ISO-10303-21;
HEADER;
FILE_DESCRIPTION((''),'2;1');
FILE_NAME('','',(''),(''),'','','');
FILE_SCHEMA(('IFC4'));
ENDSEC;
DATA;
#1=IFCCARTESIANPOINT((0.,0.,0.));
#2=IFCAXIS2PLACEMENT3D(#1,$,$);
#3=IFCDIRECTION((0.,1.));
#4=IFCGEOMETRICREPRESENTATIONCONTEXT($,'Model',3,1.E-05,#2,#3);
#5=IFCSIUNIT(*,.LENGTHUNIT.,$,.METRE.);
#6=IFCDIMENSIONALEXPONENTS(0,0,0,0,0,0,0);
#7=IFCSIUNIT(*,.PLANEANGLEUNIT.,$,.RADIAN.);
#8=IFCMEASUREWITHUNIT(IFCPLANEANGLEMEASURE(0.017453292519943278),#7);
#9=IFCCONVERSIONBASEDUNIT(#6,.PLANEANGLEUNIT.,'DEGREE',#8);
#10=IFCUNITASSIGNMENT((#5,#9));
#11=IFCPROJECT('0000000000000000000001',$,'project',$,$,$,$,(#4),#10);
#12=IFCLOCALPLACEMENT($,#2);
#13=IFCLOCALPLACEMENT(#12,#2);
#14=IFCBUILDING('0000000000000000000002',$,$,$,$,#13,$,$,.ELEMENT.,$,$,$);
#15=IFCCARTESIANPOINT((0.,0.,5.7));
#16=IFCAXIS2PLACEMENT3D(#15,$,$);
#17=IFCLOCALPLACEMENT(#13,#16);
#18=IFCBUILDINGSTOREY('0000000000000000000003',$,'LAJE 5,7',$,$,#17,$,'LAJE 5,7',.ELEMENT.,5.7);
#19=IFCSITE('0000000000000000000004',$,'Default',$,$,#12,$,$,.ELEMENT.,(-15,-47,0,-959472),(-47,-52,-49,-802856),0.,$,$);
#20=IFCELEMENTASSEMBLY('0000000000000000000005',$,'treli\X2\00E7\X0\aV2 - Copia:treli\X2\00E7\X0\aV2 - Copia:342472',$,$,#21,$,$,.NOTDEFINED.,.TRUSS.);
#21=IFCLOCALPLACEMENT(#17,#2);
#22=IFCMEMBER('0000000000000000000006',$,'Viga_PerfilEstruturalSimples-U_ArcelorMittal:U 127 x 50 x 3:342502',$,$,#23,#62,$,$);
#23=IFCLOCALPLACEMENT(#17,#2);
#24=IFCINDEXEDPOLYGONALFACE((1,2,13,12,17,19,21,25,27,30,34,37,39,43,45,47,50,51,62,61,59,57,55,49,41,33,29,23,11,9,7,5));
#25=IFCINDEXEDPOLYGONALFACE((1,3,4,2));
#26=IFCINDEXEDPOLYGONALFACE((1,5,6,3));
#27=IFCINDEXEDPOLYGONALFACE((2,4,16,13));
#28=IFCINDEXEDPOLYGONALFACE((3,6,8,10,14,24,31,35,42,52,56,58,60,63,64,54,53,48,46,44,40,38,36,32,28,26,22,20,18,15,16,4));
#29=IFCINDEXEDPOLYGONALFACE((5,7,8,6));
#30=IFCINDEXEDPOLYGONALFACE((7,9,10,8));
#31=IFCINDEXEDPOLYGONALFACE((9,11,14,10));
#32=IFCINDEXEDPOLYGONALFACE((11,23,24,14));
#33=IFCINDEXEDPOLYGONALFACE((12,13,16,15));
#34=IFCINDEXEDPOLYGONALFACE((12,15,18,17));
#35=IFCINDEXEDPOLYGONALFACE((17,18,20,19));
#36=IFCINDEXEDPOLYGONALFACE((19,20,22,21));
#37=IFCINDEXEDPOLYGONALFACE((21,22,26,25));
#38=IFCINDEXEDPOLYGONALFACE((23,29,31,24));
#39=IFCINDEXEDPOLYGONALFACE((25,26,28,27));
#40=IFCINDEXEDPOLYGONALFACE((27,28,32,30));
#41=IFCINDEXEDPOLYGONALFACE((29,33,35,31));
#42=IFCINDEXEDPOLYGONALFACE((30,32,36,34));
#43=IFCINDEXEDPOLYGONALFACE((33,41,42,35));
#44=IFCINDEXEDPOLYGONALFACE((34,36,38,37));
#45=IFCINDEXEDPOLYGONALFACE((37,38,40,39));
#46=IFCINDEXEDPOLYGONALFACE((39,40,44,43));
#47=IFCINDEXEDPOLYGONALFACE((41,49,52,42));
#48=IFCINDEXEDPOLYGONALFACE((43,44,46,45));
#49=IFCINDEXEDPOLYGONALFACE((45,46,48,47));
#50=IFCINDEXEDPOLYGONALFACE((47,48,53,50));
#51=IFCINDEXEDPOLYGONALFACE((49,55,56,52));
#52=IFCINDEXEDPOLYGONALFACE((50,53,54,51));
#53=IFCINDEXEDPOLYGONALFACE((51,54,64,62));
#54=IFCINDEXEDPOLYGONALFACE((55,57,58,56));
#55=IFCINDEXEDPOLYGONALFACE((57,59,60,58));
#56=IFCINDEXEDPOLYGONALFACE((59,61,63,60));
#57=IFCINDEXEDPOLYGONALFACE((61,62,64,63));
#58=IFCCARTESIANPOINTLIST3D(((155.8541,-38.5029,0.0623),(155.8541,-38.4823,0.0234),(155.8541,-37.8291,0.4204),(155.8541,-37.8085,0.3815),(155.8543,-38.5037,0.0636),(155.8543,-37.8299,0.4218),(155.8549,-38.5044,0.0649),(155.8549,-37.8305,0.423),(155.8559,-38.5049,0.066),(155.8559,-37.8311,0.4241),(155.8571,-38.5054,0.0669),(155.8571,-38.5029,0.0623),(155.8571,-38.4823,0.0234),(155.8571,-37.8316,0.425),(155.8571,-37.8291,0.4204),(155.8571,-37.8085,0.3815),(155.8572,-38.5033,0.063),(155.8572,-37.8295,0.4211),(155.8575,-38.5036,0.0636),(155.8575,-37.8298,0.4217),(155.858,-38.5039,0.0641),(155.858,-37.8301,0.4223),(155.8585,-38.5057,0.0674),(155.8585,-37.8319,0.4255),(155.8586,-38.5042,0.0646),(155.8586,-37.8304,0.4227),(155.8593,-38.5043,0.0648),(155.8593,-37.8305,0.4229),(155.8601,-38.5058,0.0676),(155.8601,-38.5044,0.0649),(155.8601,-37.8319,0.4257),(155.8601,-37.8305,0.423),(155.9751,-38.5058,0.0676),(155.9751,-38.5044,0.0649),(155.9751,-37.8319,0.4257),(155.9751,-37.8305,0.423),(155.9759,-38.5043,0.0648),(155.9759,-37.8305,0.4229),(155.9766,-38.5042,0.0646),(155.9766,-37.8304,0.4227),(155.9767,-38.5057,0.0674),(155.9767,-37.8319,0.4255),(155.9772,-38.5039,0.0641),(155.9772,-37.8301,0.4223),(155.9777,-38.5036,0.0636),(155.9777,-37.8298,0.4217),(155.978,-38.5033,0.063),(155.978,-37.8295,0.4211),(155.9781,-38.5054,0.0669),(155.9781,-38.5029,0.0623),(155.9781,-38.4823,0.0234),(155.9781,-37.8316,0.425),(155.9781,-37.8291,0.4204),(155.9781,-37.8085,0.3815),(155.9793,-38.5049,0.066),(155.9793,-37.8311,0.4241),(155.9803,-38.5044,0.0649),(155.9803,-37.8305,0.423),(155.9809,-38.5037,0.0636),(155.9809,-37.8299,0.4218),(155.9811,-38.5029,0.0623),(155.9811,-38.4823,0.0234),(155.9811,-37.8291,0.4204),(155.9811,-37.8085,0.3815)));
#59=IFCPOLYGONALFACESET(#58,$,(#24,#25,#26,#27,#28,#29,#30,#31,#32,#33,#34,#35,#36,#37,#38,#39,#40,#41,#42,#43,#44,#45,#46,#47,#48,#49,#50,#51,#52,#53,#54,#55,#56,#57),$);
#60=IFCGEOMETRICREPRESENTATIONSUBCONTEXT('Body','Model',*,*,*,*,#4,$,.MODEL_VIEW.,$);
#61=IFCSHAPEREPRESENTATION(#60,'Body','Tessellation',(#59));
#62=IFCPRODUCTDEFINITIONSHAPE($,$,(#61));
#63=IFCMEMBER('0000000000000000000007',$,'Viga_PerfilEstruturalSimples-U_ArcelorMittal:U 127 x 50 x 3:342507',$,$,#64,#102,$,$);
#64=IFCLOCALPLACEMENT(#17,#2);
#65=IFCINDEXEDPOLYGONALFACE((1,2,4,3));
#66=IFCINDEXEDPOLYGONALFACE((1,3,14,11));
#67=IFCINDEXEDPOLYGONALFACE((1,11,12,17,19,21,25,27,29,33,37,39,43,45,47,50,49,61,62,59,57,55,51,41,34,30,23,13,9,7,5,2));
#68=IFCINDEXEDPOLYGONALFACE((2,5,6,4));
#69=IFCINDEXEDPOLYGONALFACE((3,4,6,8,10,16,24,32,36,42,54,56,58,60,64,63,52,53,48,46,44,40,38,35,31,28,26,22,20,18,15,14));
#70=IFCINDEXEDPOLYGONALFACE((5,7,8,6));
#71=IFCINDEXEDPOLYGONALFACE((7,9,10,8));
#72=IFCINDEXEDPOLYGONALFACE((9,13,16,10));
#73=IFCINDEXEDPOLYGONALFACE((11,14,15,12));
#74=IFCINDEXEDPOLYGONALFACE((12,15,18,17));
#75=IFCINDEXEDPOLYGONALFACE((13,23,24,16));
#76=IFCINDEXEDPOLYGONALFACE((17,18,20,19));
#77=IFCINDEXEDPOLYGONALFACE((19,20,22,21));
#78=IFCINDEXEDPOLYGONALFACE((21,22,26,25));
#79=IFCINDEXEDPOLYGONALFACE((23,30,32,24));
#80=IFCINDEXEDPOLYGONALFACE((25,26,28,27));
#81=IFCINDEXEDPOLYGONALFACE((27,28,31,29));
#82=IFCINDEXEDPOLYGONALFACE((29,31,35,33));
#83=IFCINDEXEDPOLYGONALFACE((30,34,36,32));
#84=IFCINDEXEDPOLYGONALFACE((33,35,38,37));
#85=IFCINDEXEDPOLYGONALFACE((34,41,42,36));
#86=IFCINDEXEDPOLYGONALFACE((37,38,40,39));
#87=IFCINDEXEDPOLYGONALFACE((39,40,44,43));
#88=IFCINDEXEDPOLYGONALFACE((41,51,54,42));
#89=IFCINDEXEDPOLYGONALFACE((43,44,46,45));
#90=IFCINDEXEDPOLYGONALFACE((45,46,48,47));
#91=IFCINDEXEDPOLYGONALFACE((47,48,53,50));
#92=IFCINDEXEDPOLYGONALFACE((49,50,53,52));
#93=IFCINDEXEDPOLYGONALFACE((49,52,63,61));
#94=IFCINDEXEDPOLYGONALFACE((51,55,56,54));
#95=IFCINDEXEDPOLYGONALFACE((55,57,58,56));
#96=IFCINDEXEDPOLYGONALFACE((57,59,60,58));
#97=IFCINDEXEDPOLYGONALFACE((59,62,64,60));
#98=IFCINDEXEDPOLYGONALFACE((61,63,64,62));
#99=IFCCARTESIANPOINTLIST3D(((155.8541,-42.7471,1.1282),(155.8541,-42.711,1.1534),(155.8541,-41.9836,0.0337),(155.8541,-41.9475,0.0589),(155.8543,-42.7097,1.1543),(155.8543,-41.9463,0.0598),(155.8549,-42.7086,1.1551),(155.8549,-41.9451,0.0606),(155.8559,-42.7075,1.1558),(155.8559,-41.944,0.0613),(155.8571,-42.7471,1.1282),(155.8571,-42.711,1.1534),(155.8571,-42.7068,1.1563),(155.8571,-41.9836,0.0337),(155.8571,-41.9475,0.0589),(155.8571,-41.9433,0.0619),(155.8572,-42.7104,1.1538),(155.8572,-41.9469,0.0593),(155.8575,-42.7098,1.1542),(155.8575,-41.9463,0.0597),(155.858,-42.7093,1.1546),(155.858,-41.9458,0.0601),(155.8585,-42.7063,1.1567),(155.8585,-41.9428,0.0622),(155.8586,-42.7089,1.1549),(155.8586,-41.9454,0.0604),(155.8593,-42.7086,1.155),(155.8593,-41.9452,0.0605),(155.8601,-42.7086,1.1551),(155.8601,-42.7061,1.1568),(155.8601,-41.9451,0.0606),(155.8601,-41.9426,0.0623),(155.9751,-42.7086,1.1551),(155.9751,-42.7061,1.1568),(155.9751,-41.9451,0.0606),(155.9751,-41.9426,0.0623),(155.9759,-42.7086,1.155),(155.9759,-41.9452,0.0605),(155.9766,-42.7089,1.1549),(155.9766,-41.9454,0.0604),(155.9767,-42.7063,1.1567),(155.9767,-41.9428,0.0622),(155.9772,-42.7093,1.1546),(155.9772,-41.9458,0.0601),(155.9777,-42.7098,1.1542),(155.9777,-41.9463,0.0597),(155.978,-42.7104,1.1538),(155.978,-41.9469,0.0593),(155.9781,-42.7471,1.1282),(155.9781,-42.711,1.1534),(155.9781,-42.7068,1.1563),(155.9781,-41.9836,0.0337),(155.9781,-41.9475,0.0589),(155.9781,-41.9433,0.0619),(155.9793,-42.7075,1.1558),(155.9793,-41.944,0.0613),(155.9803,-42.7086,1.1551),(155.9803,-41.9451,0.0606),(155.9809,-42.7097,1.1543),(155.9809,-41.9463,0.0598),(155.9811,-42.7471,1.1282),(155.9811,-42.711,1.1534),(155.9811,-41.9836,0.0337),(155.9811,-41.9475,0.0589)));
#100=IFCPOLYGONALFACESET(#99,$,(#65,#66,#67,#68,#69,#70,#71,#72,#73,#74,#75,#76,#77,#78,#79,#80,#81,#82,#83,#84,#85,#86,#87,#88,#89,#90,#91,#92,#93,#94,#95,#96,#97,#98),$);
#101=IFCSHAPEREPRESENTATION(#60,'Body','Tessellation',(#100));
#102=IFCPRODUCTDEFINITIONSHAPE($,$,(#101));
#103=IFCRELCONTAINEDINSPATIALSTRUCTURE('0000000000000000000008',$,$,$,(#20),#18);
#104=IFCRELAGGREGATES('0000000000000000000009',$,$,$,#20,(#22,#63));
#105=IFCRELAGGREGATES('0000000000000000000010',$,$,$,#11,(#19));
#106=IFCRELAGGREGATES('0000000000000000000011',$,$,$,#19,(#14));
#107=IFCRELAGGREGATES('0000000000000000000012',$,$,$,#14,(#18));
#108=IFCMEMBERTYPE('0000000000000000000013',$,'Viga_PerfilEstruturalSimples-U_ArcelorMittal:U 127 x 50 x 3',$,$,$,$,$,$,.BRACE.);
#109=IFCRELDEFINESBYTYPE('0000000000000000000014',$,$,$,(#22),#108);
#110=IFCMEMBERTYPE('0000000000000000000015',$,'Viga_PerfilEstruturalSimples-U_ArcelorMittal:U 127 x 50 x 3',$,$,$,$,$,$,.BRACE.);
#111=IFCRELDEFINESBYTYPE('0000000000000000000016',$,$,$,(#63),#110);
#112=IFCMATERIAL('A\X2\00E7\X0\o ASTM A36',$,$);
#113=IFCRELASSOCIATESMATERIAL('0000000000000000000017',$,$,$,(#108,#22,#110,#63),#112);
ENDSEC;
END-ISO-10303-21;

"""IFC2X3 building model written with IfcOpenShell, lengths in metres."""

from ifc_helpers import new_model, entity, si_unit, converted_unit, direction, frame, frame_2d, origin, place, context, subcontext, project, spatial, polyline, circle_curve, parameter, trimmed, segment, composite_curve, outline, extrude, source, transform, mapped, material, type_object, type_shapes, element, aggregate, save


model = new_model("IFC2X3")

# Units and contexts
model_context = context("Model", 3, precision=1e-05, world=origin(), true_north=direction((0.0, 1.0)))
body_context = subcontext(model_context, "Body", "Model", "MODEL_VIEW")
ifc_project = project(units=[si_unit("LENGTHUNIT", "METRE"), converted_unit("PLANEANGLEUNIT", "DEGREE", entity("IfcPlaneAngleMeasure", 0.017453292519943278), si_unit("PLANEANGLEUNIT", "RADIAN"), dimensions=[0, 0, 0, 0, 0, 0, 0])], contexts=[model_context])

# Site, building, storey
site_placement = place(None, origin())
site = spatial("IfcSite", under=ifc_project, at=site_placement, Name="Default", CompositionType="ELEMENT", RefLatitude=(-15, -47, 0, -959472), RefLongitude=(-47, -52, -49, -802856), RefElevation=0.0)
building_placement = place(site_placement, origin())
building = spatial("IfcBuilding", under=site, at=building_placement, CompositionType="ELEMENT")
storey_placement = place(building_placement, frame((0.0, 0.0, 5.7)))
storey = spatial("IfcBuildingStorey", under=building, at=storey_placement, Name="LAJE 5,7", LongName="LAJE 5,7", CompositionType="ELEMENT", Elevation=5.7)

# Element assembly, members
ifc_material = material(Name="Aço ASTM A36")
assembly_1_placement = place(storey_placement, origin())
assembly_1 = element("IfcElementAssembly", 1, at=assembly_1_placement, inside=storey, Name="treliçaV2 - Copia:treliçaV2 - Copia:342472", AssemblyPlace="NOTDEFINED", PredefinedType="TRUSS")
member_type_1 = type_object("IfcMemberType", Name="Viga_PerfilEstruturalSimples-U_ArcelorMittal:U 127 x 50 x 3", PredefinedType="BRACE", material=ifc_material)
shared_shape_1 = source(origin(), body_context, "Body", "SweptSolid", [
    extrude(outline(composite_curve([segment(polyline([(-0.0575, -0.0192), (0.0575, -0.0192)]), True, "CONTINUOUS"), segment(trimmed(circle_curve(frame_2d((0.0575, -0.0132), x_axis=(0.0, 1.0)), 0.006), [parameter(180.0)], [parameter(270.0)], True, "PARAMETER"), True, "CONTINUOUS"), segment(polyline([(0.0635, -0.0132), (0.0635, 0.0308)]), True, "CONTINUOUS"), segment(polyline([(0.0635, 0.0308), (0.0605, 0.0308)]), True, "CONTINUOUS"), segment(polyline([(0.0605, 0.0308), (0.0605, -0.0132)]), True, "CONTINUOUS"), segment(trimmed(circle_curve(frame_2d((0.0575, -0.0132), x_axis=(0.0, 1.0)), 0.003), [parameter(180.0)], [parameter(270.0)], True, "PARAMETER"), False, "CONTINUOUS"), segment(polyline([(0.0575, -0.0162), (-0.0575, -0.0162)]), True, "CONTINUOUS"), segment(trimmed(circle_curve(frame_2d((-0.0575, -0.0132), x_axis=(0.0, 1.0)), 0.003), [parameter(90.0)], [parameter(180.0)], True, "PARAMETER"), False, "CONTINUOUS"), segment(polyline([(-0.0605, -0.0132), (-0.0605, 0.0308)]), True, "CONTINUOUS"), segment(polyline([(-0.0605, 0.0308), (-0.0635, 0.0308)]), True, "CONTINUOUS"), segment(polyline([(-0.0635, 0.0308), (-0.0635, -0.0132)]), True, "CONTINUOUS"), segment(trimmed(circle_curve(frame_2d((-0.0575, -0.0132), x_axis=(0.0, 1.0)), 0.006), [parameter(90.0)], [parameter(180.0)], True, "PARAMETER"), True, "CONTINUOUS")], self_intersect=False)), frame((-0.3773, -0.0058, 0.0), z_axis=(1.0, 0.0, 0.0), x_axis=(0.0, 0.0, -1.0)), (0.0, 0.0, 1.0), 0.7631),
])
type_shapes(member_type_1, [shared_shape_1])
member_1_placement = place(assembly_1_placement, frame((155.9176, -38.1609, 0.2226), z_axis=(-1.0, 0.0, 0.0), x_axis=(0.0, 0.883036, 0.469305)))
member_1 = element("IfcMember", 2, at=member_1_placement, type_object=member_type_1, material=ifc_material, Name="Viga_PerfilEstruturalSimples-U_ArcelorMittal:U 127 x 50 x 3:342502", context=body_context, shape_type="MappedRepresentation", body=[
    mapped(shared_shape_1, transform((0.0, 0.0, 0.0), scale=1.0)),
])
member_type_2 = type_object("IfcMemberType", Name="Viga_PerfilEstruturalSimples-U_ArcelorMittal:U 127 x 50 x 3", PredefinedType="BRACE", material=ifc_material)
shared_shape_2 = source(origin(), body_context, "Body", "SweptSolid", [
    extrude(outline(composite_curve([segment(polyline([(-0.0575, -0.0192), (0.0575, -0.0192)]), True, "CONTINUOUS"), segment(trimmed(circle_curve(frame_2d((0.0575, -0.0132), x_axis=(0.0, 1.0)), 0.006), [parameter(180.0)], [parameter(270.0)], True, "PARAMETER"), True, "CONTINUOUS"), segment(polyline([(0.0635, -0.0132), (0.0635, 0.0308)]), True, "CONTINUOUS"), segment(polyline([(0.0635, 0.0308), (0.0605, 0.0308)]), True, "CONTINUOUS"), segment(polyline([(0.0605, 0.0308), (0.0605, -0.0132)]), True, "CONTINUOUS"), segment(trimmed(circle_curve(frame_2d((0.0575, -0.0132), x_axis=(0.0, 1.0)), 0.003), [parameter(180.0)], [parameter(270.0)], True, "PARAMETER"), False, "CONTINUOUS"), segment(polyline([(0.0575, -0.0162), (-0.0575, -0.0162)]), True, "CONTINUOUS"), segment(trimmed(circle_curve(frame_2d((-0.0575, -0.0132), x_axis=(0.0, 1.0)), 0.003), [parameter(90.0)], [parameter(180.0)], True, "PARAMETER"), False, "CONTINUOUS"), segment(polyline([(-0.0605, -0.0132), (-0.0605, 0.0308)]), True, "CONTINUOUS"), segment(polyline([(-0.0605, 0.0308), (-0.0635, 0.0308)]), True, "CONTINUOUS"), segment(polyline([(-0.0635, 0.0308), (-0.0635, -0.0132)]), True, "CONTINUOUS"), segment(trimmed(circle_curve(frame_2d((-0.0575, -0.0132), x_axis=(0.0, 1.0)), 0.006), [parameter(90.0)], [parameter(180.0)], True, "PARAMETER"), True, "CONTINUOUS")], self_intersect=False)), frame((-0.6611, -0.0058, 0.0), z_axis=(1.0, 0.0, 0.0), x_axis=(0.0, 0.0, -1.0)), (0.0, 0.0, 1.0), 1.3345),
])
type_shapes(member_type_2, [shared_shape_2])
member_2_placement = place(assembly_1_placement, frame((155.9176, -42.3484, 0.6003), z_axis=(-1.0, 0.0, 0.0), x_axis=(0.0, 0.57213, -0.820163)))
member_2 = element("IfcMember", 3, at=member_2_placement, type_object=member_type_2, material=ifc_material, Name="Viga_PerfilEstruturalSimples-U_ArcelorMittal:U 127 x 50 x 3:342507", context=body_context, shape_type="MappedRepresentation", body=[
    mapped(shared_shape_2, transform((0.0, 0.0, 0.0), scale=1.0)),
])
aggregate(assembly_1, [member_1, member_2])

save(model, "model.ifc")
